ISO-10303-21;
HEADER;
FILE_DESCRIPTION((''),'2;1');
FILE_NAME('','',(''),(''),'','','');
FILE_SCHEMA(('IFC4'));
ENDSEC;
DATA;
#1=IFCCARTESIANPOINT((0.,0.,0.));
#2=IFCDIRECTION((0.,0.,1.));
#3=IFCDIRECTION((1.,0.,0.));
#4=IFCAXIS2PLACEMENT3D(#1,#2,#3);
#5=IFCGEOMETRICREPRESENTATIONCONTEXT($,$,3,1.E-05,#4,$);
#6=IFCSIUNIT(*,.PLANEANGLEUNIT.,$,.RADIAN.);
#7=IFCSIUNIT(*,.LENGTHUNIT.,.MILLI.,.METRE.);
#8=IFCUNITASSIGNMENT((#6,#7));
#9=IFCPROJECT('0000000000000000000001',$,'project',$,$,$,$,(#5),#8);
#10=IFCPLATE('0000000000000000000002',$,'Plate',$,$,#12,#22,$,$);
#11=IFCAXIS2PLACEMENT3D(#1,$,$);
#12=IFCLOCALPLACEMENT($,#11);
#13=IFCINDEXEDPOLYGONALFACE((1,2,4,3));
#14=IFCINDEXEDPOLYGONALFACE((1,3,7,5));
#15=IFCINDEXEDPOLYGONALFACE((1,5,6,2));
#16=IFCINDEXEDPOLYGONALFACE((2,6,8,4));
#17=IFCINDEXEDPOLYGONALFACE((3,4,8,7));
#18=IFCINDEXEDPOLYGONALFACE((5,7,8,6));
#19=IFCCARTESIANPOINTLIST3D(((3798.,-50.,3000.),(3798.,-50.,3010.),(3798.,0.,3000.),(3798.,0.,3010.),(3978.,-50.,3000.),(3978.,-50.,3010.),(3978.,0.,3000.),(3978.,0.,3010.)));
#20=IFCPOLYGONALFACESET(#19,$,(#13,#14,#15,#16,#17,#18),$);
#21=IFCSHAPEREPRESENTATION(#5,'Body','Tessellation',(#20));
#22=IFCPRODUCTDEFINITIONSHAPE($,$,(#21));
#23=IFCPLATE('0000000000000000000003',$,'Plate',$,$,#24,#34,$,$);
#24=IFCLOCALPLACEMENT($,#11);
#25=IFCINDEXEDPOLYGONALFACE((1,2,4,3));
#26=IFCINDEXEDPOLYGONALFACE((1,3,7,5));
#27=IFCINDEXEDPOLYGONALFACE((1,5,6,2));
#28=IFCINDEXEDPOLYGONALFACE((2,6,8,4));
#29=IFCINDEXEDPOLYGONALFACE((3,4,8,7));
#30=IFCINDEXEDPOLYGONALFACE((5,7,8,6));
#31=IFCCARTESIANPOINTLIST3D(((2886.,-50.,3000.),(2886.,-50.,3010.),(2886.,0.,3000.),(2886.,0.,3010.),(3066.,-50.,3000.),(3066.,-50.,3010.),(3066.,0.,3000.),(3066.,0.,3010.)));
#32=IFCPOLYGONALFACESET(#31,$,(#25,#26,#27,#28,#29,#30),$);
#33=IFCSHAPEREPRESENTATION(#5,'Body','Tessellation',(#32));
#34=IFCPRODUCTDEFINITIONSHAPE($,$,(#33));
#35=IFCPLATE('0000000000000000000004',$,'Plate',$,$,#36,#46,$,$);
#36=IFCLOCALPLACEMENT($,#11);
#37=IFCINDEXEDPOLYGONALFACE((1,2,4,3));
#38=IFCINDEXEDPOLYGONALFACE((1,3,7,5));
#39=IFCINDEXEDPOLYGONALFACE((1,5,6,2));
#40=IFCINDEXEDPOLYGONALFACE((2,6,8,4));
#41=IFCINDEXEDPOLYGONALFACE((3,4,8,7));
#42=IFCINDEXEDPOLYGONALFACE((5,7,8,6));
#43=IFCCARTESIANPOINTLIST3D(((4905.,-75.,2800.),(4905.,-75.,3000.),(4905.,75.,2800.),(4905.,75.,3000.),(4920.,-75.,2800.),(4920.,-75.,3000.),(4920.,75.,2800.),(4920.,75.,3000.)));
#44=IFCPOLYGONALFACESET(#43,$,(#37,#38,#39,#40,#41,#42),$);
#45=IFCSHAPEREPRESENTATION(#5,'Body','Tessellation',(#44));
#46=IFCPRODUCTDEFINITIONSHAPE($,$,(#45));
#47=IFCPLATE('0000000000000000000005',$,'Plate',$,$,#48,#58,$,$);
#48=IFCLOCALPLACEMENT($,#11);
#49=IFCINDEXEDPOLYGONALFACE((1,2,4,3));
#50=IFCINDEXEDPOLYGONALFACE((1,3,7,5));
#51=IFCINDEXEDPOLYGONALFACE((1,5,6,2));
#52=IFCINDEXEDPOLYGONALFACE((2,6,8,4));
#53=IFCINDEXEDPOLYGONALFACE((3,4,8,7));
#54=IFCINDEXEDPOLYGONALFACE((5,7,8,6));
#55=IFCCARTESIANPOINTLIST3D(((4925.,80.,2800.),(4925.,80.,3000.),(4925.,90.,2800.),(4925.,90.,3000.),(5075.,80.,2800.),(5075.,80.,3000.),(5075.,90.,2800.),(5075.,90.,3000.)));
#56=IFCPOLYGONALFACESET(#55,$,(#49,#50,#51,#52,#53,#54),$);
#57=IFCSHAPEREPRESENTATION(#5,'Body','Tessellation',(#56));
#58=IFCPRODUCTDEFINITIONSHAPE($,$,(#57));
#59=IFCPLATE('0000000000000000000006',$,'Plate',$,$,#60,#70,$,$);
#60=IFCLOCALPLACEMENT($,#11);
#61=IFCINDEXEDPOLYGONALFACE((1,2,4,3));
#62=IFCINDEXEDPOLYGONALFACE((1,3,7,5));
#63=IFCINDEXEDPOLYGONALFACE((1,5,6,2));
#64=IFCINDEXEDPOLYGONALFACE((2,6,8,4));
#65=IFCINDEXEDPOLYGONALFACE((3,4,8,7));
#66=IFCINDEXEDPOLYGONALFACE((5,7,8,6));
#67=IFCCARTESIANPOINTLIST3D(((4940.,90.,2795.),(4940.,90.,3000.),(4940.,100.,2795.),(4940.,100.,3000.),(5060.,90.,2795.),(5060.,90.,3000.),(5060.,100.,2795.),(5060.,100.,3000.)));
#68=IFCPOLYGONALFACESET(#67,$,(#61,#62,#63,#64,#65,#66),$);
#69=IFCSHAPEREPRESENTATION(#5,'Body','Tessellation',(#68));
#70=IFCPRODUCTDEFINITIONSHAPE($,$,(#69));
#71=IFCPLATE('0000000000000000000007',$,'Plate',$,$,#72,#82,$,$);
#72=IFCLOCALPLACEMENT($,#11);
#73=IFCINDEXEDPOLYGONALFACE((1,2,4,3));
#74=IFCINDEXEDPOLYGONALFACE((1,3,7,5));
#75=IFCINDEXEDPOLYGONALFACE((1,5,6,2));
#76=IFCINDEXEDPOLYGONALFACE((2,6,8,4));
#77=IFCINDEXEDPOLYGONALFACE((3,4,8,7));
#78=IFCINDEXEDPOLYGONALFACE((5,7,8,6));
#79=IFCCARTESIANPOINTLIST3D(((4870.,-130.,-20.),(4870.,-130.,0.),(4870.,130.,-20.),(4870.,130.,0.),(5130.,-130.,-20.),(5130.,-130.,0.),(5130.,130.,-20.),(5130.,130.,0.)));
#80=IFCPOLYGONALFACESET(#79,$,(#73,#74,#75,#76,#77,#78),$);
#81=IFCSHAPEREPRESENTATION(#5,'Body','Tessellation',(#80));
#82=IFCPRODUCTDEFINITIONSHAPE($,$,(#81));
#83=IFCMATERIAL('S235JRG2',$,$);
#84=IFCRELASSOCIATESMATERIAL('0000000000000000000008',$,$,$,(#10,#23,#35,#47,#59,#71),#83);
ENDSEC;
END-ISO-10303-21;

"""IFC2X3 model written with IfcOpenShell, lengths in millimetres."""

from ifc_helpers import new_model, si_unit, frame, origin_with_axes, place, context, project, polyline, outline, extrude, material, element, save


model = new_model("IFC2X3")

# Units and contexts
context_of_model = context(None, 3, precision=1e-05, world=origin_with_axes())
ifc_project = project(units=[si_unit("PLANEANGLEUNIT", "RADIAN"), si_unit("LENGTHUNIT", "METRE", prefix="MILLI")], contexts=[context_of_model])

# Shared definitions
ifc_material = material(Name="S235JRG2")

# Plates
placement_1 = place(None, origin_with_axes())
plate_1_placement = place(placement_1, frame((3978.0, -50.0, 3010.0), z_axis=(0.0, 1.0, 0.0), x_axis=(0.0, 0.0, -1.0)))
element("IfcPlate", 1, at=plate_1_placement, material=ifc_material, Name="Plate", context=context_of_model, shape_type="SweptSolid", body=[
    extrude(outline(polyline([(0.0, 0.0), (180.0, 0.0), (180.0, 50.0), (0.0, 50.0), (0.0, 0.0)])), frame((0.0, 0.0, 0.0), z_axis=(1.0, 0.0, 0.0), x_axis=(0.0, 1.0, 0.0)), (0.0, 0.0, 1.0), 10.0),
])
placement_2 = place(None, origin_with_axes())
plate_2_placement = place(placement_2, frame((3066.0, -50.0, 3010.0), z_axis=(0.0, 1.0, 0.0), x_axis=(0.0, 0.0, -1.0)))
element("IfcPlate", 2, at=plate_2_placement, material=ifc_material, Name="Plate", context=context_of_model, shape_type="SweptSolid", body=[
    extrude(outline(polyline([(0.0, 0.0), (180.0, 0.0), (180.0, 50.0), (0.0, 50.0), (0.0, 0.0)])), frame((0.0, 0.0, 0.0), z_axis=(1.0, 0.0, 0.0), x_axis=(0.0, 1.0, 0.0)), (0.0, 0.0, 1.0), 10.0),
])
placement_3 = place(None, origin_with_axes())
plate_3_placement = place(placement_3, frame((4905.0, 75.0, 2800.0), z_axis=(0.0, -1.0, 0.0), x_axis=(1.0, 0.0, 0.0)))
element("IfcPlate", 3, at=plate_3_placement, material=ifc_material, Name="Plate", context=context_of_model, shape_type="SweptSolid", body=[
    extrude(outline(polyline([(0.0, 0.0), (200.0, 0.0), (200.0, 150.0), (0.0, 150.0), (0.0, 0.0)])), frame((0.0, 0.0, 0.0), z_axis=(1.0, 0.0, 0.0), x_axis=(0.0, 1.0, 0.0)), (0.0, 0.0, 1.0), 15.0),
])
placement_4 = place(None, origin_with_axes())
plate_4_placement = place(placement_4, frame((4925.0, 80.0, 3000.0), z_axis=(0.0, 0.0, -1.0), x_axis=(0.0, 1.0, 0.0)))
element("IfcPlate", 4, at=plate_4_placement, material=ifc_material, Name="Plate", context=context_of_model, shape_type="SweptSolid", body=[
    extrude(outline(polyline([(0.0, 0.0), (150.0, 0.0), (150.0, 200.0), (0.0, 200.0), (0.0, 0.0)])), frame((0.0, 0.0, 0.0), z_axis=(1.0, 0.0, 0.0), x_axis=(0.0, 1.0, 0.0)), (0.0, 0.0, 1.0), 10.0),
])
placement_5 = place(None, origin_with_axes())
plate_5_placement = place(placement_5, frame((5060.0, 100.0, 3000.0), z_axis=(0.0, 0.0, -1.0), x_axis=(0.0, -1.0, 0.0)))
element("IfcPlate", 5, at=plate_5_placement, material=ifc_material, Name="Plate", context=context_of_model, shape_type="SweptSolid", body=[
    extrude(outline(polyline([(0.0, 0.0), (120.0, 0.0), (120.0, 205.0), (0.0, 205.0), (0.0, 0.0)])), frame((0.0, 0.0, 0.0), z_axis=(1.0, 0.0, 0.0), x_axis=(0.0, 1.0, 0.0)), (0.0, 0.0, 1.0), 10.0),
])
placement_6 = place(None, origin_with_axes())
plate_6_placement = place(placement_6, frame((4870.0, -130.0, 0.0), z_axis=(1.0, 0.0, 0.0), x_axis=(0.0, 0.0, -1.0)))
element("IfcPlate", 6, at=plate_6_placement, material=ifc_material, Name="Plate", context=context_of_model, shape_type="SweptSolid", body=[
    extrude(outline(polyline([(0.0, 0.0), (260.0, 0.0), (260.0, 260.0), (0.0, 260.0), (0.0, 0.0)])), frame((0.0, 0.0, 0.0), z_axis=(1.0, 0.0, 0.0), x_axis=(0.0, 1.0, 0.0)), (0.0, 0.0, 1.0), 20.0),
])

save(model, "model.ifc")
